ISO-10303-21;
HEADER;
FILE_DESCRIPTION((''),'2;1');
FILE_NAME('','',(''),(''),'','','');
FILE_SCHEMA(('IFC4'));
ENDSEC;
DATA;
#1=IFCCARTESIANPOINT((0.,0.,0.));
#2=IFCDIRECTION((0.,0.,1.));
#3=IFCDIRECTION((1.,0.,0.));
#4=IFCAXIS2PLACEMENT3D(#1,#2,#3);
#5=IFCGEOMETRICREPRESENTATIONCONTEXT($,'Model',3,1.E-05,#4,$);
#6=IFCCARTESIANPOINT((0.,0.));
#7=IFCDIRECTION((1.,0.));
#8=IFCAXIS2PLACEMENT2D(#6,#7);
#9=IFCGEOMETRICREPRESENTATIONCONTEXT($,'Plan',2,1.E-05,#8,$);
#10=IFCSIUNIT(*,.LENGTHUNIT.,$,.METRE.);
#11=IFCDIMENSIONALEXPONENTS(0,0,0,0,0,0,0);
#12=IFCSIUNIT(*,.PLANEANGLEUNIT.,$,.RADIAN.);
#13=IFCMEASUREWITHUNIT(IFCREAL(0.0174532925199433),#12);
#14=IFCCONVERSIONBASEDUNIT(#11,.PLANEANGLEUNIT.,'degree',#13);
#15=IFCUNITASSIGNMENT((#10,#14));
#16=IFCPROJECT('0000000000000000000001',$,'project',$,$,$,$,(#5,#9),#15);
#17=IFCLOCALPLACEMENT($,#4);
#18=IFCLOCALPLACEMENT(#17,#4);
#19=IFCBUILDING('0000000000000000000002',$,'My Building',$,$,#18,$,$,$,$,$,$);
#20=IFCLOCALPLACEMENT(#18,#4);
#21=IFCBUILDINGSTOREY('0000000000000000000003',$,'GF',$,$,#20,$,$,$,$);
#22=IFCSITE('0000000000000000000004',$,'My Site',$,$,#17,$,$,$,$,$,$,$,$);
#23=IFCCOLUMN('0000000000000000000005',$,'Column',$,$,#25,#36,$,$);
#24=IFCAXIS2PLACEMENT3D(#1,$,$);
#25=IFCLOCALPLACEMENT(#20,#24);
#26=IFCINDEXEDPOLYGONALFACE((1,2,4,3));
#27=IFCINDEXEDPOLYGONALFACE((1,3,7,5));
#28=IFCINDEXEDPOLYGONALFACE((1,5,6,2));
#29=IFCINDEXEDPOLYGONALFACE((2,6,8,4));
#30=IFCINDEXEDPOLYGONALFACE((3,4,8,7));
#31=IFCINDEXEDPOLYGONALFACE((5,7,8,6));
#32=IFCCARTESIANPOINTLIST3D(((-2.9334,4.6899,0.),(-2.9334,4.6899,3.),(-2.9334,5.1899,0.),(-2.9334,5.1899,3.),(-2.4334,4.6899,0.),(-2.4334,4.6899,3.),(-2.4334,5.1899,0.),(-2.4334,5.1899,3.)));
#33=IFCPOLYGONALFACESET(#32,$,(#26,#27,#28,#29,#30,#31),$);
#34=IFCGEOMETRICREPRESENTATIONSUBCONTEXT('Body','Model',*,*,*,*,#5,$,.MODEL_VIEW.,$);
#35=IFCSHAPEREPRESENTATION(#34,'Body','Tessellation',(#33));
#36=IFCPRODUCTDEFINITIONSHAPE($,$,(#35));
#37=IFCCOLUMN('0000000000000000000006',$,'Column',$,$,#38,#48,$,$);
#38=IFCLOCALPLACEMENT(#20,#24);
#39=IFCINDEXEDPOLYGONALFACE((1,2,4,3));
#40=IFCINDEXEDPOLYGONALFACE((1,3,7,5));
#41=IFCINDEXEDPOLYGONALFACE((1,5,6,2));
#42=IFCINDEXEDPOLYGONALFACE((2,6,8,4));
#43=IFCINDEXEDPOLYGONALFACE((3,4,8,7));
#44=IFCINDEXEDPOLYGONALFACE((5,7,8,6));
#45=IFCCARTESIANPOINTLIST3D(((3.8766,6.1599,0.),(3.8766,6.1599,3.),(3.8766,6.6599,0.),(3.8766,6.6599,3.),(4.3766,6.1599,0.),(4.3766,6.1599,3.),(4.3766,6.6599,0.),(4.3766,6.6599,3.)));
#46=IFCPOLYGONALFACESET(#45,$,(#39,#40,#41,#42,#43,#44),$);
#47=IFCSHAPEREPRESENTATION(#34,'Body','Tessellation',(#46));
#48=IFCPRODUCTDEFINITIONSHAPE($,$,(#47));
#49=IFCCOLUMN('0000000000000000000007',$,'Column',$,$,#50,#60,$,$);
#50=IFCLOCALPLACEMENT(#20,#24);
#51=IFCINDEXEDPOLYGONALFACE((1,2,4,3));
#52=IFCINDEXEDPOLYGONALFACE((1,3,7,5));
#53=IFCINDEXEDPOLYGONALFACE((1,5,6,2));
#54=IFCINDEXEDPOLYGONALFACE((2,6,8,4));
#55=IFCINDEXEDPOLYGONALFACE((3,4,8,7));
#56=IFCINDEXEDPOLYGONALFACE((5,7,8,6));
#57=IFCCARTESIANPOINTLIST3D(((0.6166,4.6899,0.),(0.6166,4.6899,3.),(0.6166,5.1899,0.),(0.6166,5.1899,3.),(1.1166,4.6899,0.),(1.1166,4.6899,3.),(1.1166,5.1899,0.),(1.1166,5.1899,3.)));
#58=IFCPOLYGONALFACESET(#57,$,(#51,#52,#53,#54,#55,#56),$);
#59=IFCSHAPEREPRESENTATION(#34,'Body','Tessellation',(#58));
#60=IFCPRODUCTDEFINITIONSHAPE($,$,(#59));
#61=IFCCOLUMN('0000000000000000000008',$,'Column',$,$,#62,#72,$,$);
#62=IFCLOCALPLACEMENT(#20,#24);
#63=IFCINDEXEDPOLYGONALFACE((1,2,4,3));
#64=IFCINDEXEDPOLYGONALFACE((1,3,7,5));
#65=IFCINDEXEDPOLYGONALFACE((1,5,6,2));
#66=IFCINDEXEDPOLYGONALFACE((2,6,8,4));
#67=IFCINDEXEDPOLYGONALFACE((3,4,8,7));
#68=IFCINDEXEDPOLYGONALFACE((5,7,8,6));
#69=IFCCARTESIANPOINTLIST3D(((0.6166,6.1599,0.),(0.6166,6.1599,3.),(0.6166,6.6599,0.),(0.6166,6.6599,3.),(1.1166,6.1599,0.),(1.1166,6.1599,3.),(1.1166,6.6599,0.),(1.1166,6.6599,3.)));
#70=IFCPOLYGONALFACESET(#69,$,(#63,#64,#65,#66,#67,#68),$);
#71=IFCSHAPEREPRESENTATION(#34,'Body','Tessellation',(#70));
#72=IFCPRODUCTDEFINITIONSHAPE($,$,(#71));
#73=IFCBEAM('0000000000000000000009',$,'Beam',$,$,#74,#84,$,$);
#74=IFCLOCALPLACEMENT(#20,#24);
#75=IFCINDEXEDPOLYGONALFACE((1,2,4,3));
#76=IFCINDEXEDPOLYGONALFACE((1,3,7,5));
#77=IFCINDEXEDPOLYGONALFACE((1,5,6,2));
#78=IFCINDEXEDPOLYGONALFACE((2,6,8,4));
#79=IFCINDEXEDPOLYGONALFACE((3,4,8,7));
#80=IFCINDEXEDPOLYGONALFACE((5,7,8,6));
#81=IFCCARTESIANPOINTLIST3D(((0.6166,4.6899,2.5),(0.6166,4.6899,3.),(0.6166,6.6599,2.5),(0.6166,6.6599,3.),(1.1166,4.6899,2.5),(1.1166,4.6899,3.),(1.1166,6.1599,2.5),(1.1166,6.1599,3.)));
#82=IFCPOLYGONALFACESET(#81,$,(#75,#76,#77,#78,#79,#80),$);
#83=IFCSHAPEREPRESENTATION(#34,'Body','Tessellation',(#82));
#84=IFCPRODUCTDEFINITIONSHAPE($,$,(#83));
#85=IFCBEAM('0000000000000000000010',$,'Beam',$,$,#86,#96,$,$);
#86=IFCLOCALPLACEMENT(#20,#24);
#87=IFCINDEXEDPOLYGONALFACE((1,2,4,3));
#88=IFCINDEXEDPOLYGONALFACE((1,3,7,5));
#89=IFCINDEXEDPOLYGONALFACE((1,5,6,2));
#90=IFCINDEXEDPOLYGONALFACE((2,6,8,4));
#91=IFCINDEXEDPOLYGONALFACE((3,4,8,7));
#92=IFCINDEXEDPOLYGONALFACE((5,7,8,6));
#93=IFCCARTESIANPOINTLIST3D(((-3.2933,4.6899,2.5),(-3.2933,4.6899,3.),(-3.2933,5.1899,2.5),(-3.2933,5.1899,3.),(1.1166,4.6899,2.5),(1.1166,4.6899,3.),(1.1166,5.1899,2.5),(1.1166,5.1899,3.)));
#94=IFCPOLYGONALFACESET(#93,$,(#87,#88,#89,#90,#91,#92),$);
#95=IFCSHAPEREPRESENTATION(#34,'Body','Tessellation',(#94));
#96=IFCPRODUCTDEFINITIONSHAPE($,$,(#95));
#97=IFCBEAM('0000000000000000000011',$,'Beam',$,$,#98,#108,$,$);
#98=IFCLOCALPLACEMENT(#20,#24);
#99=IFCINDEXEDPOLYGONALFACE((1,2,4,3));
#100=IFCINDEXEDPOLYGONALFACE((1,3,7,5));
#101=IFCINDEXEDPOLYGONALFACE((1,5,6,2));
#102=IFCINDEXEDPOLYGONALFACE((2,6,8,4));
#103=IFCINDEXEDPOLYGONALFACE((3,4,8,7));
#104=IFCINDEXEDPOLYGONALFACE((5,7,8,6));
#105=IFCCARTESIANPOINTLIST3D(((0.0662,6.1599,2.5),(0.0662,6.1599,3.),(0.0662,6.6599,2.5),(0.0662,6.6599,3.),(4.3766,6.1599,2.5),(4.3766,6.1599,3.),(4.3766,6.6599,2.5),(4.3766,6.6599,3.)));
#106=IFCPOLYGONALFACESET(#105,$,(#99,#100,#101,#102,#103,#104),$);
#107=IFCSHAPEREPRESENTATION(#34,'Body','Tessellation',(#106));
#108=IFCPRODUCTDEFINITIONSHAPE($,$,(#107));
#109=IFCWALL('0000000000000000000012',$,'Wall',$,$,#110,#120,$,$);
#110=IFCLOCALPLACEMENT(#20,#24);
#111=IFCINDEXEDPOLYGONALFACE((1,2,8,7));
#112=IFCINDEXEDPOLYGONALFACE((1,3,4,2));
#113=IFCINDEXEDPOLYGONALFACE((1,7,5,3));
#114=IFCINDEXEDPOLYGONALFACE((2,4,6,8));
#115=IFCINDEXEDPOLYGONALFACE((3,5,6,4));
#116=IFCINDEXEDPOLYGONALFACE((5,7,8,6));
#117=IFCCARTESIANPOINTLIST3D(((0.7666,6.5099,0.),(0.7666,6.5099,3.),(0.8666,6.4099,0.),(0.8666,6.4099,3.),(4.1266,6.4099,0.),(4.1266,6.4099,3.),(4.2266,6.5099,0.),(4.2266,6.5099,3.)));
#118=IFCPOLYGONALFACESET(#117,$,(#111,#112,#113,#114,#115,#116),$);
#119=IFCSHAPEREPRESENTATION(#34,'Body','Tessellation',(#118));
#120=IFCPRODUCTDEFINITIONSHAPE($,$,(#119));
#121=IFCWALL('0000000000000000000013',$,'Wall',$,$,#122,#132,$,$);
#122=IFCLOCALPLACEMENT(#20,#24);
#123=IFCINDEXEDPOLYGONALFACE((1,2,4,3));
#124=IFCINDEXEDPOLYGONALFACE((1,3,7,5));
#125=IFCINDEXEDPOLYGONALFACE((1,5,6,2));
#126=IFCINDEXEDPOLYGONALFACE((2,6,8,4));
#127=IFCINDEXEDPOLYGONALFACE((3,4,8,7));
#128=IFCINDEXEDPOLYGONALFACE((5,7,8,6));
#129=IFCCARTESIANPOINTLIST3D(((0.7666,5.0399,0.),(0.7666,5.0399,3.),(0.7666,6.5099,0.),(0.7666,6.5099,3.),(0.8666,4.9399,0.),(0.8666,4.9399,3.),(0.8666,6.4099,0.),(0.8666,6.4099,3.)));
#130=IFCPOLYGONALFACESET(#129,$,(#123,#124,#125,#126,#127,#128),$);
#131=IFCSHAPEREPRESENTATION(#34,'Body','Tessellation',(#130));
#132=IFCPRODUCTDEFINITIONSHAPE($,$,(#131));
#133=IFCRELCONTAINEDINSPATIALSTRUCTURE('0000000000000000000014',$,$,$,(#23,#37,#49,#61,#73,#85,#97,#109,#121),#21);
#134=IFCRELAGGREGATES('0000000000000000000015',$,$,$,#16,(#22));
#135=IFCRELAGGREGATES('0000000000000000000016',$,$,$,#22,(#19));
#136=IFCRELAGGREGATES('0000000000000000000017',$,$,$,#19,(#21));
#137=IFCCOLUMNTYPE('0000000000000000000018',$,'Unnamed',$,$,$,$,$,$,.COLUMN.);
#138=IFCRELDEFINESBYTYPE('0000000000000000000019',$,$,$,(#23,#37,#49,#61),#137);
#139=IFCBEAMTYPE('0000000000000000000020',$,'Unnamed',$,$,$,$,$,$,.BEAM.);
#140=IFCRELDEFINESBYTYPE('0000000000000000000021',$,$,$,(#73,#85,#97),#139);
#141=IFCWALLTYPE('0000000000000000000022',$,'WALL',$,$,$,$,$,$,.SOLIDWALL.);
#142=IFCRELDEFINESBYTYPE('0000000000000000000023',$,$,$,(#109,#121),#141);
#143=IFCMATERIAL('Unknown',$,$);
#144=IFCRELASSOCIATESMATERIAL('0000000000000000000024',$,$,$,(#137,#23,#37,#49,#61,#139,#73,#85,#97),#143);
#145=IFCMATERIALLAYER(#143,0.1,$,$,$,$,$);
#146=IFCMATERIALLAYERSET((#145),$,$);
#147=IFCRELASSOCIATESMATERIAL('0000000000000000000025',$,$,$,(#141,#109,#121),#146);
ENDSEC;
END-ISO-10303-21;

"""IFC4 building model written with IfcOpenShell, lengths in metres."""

from ifc_helpers import new_model, entity, si_unit, converted_unit, frame, origin_with_axes, origin_2d_with_axis, place, context, subcontext, project, spatial, line, indexed_curve, rectangle, outline, extrude, clip, halfspace, material, layer, layer_set, layer_usage, material_profile, profile_set, profile_usage, type_object, element, save


model = new_model("IFC4")

# Units and contexts
model_context = context("Model", 3, precision=1e-05, world=origin_with_axes())
plan_context = context("Plan", 2, precision=1e-05, world=origin_2d_with_axis())
body_context_1 = subcontext(model_context, "Body", "Model", "MODEL_VIEW")
ifc_project = project(units=[si_unit("LENGTHUNIT", "METRE"), converted_unit("PLANEANGLEUNIT", "degree", entity("IfcReal", 0.0174532925199433), si_unit("PLANEANGLEUNIT", "RADIAN"), dimensions=[0, 0, 0, 0, 0, 0, 0])], contexts=[model_context, plan_context])

# Site, building, storey
site_placement = place(None, origin_with_axes())
site = spatial("IfcSite", under=ifc_project, at=site_placement, Name="My Site")
building_placement = place(site_placement, origin_with_axes())
building = spatial("IfcBuilding", under=site, at=building_placement, Name="My Building")
storey_placement = place(building_placement, origin_with_axes())
storey = spatial("IfcBuildingStorey", under=building, at=storey_placement, Name="GF")

# Columns
ifc_material = material(Name="Unknown")
ifc_material_profile_1 = material_profile(ifc_material, rectangle(XDim=0.5, YDim=0.5))
ifc_profile_set_1 = profile_set([ifc_material_profile_1])
ifc_profile_usage_1 = profile_usage(ifc_profile_set_1, cardinal=5)
column_type = type_object("IfcColumnType", Name="Unnamed", PredefinedType="COLUMN", material=ifc_profile_set_1)
column_1_placement = place(storey_placement, frame((-2.6834, 4.9399, 0.0), z_axis=(0.0, 0.0, 1.0), x_axis=(1.0, 0.0, 0.0)))
element("IfcColumn", 1, at=column_1_placement, inside=storey, type_object=column_type, material=ifc_profile_usage_1, Name="Column", context=body_context_1, shape_type="SweptSolid", body=[
    extrude(rectangle(XDim=0.5, YDim=0.5), origin_with_axes(), (0.0, 0.0, 1.0), 3.0),
])
ifc_profile_usage_2 = profile_usage(ifc_profile_set_1, cardinal=5)
column_2_placement = place(storey_placement, frame((4.1266, 6.4099, 0.0), z_axis=(0.0, 0.0, 1.0), x_axis=(1.0, 0.0, 0.0)))
element("IfcColumn", 2, at=column_2_placement, inside=storey, type_object=column_type, material=ifc_profile_usage_2, Name="Column", context=body_context_1, shape_type="SweptSolid", body=[
    extrude(rectangle(XDim=0.5, YDim=0.5), origin_with_axes(), (0.0, 0.0, 1.0), 3.0),
])
ifc_profile_usage_3 = profile_usage(ifc_profile_set_1, cardinal=5)
column_3_placement = place(storey_placement, frame((0.8666, 4.9399, 0.0), z_axis=(0.0, 0.0, 1.0), x_axis=(1.0, 0.0, 0.0)))
element("IfcColumn", 3, at=column_3_placement, inside=storey, type_object=column_type, material=ifc_profile_usage_3, Name="Column", context=body_context_1, shape_type="SweptSolid", body=[
    extrude(rectangle(XDim=0.5, YDim=0.5), origin_with_axes(), (0.0, 0.0, 1.0), 3.0),
])
ifc_profile_usage_4 = profile_usage(ifc_profile_set_1, cardinal=5)
column_4_placement = place(storey_placement, frame((0.8666, 6.4099, 0.0), z_axis=(0.0, 0.0, 1.0), x_axis=(1.0, 0.0, 0.0)))
element("IfcColumn", 4, at=column_4_placement, inside=storey, type_object=column_type, material=ifc_profile_usage_4, Name="Column", context=body_context_1, shape_type="SweptSolid", body=[
    extrude(rectangle(XDim=0.5, YDim=0.5), origin_with_axes(), (0.0, 0.0, 1.0), 3.0),
])

# Beams
ifc_material_profile_2 = material_profile(ifc_material, rectangle(XDim=0.5, YDim=0.5))
ifc_profile_set_2 = profile_set([ifc_material_profile_2])
ifc_profile_usage_5 = profile_usage(ifc_profile_set_2, cardinal=7)
beam_type = type_object("IfcBeamType", Name="Unnamed", PredefinedType="BEAM", material=ifc_profile_set_2)
beam_1_placement = place(storey_placement, frame((0.6166, 4.6899, 3.0), z_axis=(0.0, 1.0, 0.0), x_axis=(-1.0, 0.0, 0.0)))
element("IfcBeam", 5, at=beam_1_placement, inside=storey, type_object=beam_type, material=ifc_profile_usage_5, Name="Beam", context=body_context_1, shape_type="Clipping", body=[
    clip(extrude(rectangle(XDim=0.5, YDim=0.5), frame((-0.25, -0.25, 0.0), z_axis=(0.0, 0.0, 1.0), x_axis=(1.0, 0.0, 0.0)), (0.0, 0.0, 1.0), 1.97), halfspace(frame((0.0, -3.0, 1.97), z_axis=(-0.707107, 0.0, 0.707107), x_axis=(0.0, 1.0, 0.0)), False)),
])
ifc_profile_usage_6 = profile_usage(ifc_profile_set_2, cardinal=7)
beam_2_placement = place(storey_placement, frame((1.1166, 4.6899, 3.0), z_axis=(-1.0, 0.0, 0.0), x_axis=(0.0, -1.0, 0.0)))
element("IfcBeam", 6, at=beam_2_placement, inside=storey, type_object=beam_type, material=ifc_profile_usage_6, Name="Beam", context=body_context_1, shape_type="SweptSolid", body=[
    extrude(rectangle(XDim=0.5, YDim=0.5), frame((-0.25, -0.25, 0.0), z_axis=(0.0, 0.0, 1.0), x_axis=(1.0, 0.0, 0.0)), (0.0, 0.0, 1.0), 4.4099),
])
ifc_profile_usage_7 = profile_usage(ifc_profile_set_2, cardinal=7)
beam_3_placement = place(storey_placement, frame((0.0662, 6.6599, 3.0), z_axis=(1.0, 0.0, 0.0), x_axis=(0.0, 1.0, 0.0)))
element("IfcBeam", 7, at=beam_3_placement, inside=storey, type_object=beam_type, material=ifc_profile_usage_7, Name="Beam", context=body_context_1, shape_type="SweptSolid", body=[
    extrude(rectangle(XDim=0.5, YDim=0.5), frame((-0.25, -0.25, 0.0), z_axis=(0.0, 0.0, 1.0), x_axis=(1.0, 0.0, 0.0)), (0.0, 0.0, 1.0), 4.3104),
])

# Walls
ifc_layer = layer(ifc_material, 0.1)
ifc_layer_set = layer_set([ifc_layer])
ifc_layer_usage_1 = layer_usage(ifc_layer_set, "AXIS2", "POSITIVE", 0.0)
wall_type = type_object("IfcWallType", Name="WALL", PredefinedType="SOLIDWALL", material=ifc_layer_set)
wall_1_placement = place(storey_placement, frame((4.2266, 6.5099, 0.0), z_axis=(0.0, 0.0, 1.0), x_axis=(-1.0, 0.0, 0.0)))
element("IfcWall", 8, at=wall_1_placement, inside=storey, type_object=wall_type, material=ifc_layer_usage_1, Name="Wall", context=body_context_1, shape_type="SweptSolid", body=[
    extrude(outline(indexed_curve([(0.0, 0.0), (0.1, 0.1), (3.36, 0.1), (3.46, 0.0)], segments=[line(1, 2, 3, 4, 1)])), origin_with_axes(), (0.0, 0.0, 1.0), 3.0),
])
ifc_layer_usage_2 = layer_usage(ifc_layer_set, "AXIS2", "POSITIVE", 0.0)
wall_2_placement = place(storey_placement, frame((0.7666, 6.5099, 0.0), z_axis=(0.0, 0.0, 1.0), x_axis=(0.0, -1.0, 0.0)))
element("IfcWall", 9, at=wall_2_placement, inside=storey, type_object=wall_type, material=ifc_layer_usage_2, Name="Wall", context=body_context_1, shape_type="SweptSolid", body=[
    extrude(outline(indexed_curve([(0.0, 0.0), (0.1, 0.1), (1.57, 0.1), (1.47, 0.0)], segments=[line(1, 2, 3, 4, 1)])), origin_with_axes(), (0.0, 0.0, 1.0), 3.0),
])

save(model, "model.ifc")
